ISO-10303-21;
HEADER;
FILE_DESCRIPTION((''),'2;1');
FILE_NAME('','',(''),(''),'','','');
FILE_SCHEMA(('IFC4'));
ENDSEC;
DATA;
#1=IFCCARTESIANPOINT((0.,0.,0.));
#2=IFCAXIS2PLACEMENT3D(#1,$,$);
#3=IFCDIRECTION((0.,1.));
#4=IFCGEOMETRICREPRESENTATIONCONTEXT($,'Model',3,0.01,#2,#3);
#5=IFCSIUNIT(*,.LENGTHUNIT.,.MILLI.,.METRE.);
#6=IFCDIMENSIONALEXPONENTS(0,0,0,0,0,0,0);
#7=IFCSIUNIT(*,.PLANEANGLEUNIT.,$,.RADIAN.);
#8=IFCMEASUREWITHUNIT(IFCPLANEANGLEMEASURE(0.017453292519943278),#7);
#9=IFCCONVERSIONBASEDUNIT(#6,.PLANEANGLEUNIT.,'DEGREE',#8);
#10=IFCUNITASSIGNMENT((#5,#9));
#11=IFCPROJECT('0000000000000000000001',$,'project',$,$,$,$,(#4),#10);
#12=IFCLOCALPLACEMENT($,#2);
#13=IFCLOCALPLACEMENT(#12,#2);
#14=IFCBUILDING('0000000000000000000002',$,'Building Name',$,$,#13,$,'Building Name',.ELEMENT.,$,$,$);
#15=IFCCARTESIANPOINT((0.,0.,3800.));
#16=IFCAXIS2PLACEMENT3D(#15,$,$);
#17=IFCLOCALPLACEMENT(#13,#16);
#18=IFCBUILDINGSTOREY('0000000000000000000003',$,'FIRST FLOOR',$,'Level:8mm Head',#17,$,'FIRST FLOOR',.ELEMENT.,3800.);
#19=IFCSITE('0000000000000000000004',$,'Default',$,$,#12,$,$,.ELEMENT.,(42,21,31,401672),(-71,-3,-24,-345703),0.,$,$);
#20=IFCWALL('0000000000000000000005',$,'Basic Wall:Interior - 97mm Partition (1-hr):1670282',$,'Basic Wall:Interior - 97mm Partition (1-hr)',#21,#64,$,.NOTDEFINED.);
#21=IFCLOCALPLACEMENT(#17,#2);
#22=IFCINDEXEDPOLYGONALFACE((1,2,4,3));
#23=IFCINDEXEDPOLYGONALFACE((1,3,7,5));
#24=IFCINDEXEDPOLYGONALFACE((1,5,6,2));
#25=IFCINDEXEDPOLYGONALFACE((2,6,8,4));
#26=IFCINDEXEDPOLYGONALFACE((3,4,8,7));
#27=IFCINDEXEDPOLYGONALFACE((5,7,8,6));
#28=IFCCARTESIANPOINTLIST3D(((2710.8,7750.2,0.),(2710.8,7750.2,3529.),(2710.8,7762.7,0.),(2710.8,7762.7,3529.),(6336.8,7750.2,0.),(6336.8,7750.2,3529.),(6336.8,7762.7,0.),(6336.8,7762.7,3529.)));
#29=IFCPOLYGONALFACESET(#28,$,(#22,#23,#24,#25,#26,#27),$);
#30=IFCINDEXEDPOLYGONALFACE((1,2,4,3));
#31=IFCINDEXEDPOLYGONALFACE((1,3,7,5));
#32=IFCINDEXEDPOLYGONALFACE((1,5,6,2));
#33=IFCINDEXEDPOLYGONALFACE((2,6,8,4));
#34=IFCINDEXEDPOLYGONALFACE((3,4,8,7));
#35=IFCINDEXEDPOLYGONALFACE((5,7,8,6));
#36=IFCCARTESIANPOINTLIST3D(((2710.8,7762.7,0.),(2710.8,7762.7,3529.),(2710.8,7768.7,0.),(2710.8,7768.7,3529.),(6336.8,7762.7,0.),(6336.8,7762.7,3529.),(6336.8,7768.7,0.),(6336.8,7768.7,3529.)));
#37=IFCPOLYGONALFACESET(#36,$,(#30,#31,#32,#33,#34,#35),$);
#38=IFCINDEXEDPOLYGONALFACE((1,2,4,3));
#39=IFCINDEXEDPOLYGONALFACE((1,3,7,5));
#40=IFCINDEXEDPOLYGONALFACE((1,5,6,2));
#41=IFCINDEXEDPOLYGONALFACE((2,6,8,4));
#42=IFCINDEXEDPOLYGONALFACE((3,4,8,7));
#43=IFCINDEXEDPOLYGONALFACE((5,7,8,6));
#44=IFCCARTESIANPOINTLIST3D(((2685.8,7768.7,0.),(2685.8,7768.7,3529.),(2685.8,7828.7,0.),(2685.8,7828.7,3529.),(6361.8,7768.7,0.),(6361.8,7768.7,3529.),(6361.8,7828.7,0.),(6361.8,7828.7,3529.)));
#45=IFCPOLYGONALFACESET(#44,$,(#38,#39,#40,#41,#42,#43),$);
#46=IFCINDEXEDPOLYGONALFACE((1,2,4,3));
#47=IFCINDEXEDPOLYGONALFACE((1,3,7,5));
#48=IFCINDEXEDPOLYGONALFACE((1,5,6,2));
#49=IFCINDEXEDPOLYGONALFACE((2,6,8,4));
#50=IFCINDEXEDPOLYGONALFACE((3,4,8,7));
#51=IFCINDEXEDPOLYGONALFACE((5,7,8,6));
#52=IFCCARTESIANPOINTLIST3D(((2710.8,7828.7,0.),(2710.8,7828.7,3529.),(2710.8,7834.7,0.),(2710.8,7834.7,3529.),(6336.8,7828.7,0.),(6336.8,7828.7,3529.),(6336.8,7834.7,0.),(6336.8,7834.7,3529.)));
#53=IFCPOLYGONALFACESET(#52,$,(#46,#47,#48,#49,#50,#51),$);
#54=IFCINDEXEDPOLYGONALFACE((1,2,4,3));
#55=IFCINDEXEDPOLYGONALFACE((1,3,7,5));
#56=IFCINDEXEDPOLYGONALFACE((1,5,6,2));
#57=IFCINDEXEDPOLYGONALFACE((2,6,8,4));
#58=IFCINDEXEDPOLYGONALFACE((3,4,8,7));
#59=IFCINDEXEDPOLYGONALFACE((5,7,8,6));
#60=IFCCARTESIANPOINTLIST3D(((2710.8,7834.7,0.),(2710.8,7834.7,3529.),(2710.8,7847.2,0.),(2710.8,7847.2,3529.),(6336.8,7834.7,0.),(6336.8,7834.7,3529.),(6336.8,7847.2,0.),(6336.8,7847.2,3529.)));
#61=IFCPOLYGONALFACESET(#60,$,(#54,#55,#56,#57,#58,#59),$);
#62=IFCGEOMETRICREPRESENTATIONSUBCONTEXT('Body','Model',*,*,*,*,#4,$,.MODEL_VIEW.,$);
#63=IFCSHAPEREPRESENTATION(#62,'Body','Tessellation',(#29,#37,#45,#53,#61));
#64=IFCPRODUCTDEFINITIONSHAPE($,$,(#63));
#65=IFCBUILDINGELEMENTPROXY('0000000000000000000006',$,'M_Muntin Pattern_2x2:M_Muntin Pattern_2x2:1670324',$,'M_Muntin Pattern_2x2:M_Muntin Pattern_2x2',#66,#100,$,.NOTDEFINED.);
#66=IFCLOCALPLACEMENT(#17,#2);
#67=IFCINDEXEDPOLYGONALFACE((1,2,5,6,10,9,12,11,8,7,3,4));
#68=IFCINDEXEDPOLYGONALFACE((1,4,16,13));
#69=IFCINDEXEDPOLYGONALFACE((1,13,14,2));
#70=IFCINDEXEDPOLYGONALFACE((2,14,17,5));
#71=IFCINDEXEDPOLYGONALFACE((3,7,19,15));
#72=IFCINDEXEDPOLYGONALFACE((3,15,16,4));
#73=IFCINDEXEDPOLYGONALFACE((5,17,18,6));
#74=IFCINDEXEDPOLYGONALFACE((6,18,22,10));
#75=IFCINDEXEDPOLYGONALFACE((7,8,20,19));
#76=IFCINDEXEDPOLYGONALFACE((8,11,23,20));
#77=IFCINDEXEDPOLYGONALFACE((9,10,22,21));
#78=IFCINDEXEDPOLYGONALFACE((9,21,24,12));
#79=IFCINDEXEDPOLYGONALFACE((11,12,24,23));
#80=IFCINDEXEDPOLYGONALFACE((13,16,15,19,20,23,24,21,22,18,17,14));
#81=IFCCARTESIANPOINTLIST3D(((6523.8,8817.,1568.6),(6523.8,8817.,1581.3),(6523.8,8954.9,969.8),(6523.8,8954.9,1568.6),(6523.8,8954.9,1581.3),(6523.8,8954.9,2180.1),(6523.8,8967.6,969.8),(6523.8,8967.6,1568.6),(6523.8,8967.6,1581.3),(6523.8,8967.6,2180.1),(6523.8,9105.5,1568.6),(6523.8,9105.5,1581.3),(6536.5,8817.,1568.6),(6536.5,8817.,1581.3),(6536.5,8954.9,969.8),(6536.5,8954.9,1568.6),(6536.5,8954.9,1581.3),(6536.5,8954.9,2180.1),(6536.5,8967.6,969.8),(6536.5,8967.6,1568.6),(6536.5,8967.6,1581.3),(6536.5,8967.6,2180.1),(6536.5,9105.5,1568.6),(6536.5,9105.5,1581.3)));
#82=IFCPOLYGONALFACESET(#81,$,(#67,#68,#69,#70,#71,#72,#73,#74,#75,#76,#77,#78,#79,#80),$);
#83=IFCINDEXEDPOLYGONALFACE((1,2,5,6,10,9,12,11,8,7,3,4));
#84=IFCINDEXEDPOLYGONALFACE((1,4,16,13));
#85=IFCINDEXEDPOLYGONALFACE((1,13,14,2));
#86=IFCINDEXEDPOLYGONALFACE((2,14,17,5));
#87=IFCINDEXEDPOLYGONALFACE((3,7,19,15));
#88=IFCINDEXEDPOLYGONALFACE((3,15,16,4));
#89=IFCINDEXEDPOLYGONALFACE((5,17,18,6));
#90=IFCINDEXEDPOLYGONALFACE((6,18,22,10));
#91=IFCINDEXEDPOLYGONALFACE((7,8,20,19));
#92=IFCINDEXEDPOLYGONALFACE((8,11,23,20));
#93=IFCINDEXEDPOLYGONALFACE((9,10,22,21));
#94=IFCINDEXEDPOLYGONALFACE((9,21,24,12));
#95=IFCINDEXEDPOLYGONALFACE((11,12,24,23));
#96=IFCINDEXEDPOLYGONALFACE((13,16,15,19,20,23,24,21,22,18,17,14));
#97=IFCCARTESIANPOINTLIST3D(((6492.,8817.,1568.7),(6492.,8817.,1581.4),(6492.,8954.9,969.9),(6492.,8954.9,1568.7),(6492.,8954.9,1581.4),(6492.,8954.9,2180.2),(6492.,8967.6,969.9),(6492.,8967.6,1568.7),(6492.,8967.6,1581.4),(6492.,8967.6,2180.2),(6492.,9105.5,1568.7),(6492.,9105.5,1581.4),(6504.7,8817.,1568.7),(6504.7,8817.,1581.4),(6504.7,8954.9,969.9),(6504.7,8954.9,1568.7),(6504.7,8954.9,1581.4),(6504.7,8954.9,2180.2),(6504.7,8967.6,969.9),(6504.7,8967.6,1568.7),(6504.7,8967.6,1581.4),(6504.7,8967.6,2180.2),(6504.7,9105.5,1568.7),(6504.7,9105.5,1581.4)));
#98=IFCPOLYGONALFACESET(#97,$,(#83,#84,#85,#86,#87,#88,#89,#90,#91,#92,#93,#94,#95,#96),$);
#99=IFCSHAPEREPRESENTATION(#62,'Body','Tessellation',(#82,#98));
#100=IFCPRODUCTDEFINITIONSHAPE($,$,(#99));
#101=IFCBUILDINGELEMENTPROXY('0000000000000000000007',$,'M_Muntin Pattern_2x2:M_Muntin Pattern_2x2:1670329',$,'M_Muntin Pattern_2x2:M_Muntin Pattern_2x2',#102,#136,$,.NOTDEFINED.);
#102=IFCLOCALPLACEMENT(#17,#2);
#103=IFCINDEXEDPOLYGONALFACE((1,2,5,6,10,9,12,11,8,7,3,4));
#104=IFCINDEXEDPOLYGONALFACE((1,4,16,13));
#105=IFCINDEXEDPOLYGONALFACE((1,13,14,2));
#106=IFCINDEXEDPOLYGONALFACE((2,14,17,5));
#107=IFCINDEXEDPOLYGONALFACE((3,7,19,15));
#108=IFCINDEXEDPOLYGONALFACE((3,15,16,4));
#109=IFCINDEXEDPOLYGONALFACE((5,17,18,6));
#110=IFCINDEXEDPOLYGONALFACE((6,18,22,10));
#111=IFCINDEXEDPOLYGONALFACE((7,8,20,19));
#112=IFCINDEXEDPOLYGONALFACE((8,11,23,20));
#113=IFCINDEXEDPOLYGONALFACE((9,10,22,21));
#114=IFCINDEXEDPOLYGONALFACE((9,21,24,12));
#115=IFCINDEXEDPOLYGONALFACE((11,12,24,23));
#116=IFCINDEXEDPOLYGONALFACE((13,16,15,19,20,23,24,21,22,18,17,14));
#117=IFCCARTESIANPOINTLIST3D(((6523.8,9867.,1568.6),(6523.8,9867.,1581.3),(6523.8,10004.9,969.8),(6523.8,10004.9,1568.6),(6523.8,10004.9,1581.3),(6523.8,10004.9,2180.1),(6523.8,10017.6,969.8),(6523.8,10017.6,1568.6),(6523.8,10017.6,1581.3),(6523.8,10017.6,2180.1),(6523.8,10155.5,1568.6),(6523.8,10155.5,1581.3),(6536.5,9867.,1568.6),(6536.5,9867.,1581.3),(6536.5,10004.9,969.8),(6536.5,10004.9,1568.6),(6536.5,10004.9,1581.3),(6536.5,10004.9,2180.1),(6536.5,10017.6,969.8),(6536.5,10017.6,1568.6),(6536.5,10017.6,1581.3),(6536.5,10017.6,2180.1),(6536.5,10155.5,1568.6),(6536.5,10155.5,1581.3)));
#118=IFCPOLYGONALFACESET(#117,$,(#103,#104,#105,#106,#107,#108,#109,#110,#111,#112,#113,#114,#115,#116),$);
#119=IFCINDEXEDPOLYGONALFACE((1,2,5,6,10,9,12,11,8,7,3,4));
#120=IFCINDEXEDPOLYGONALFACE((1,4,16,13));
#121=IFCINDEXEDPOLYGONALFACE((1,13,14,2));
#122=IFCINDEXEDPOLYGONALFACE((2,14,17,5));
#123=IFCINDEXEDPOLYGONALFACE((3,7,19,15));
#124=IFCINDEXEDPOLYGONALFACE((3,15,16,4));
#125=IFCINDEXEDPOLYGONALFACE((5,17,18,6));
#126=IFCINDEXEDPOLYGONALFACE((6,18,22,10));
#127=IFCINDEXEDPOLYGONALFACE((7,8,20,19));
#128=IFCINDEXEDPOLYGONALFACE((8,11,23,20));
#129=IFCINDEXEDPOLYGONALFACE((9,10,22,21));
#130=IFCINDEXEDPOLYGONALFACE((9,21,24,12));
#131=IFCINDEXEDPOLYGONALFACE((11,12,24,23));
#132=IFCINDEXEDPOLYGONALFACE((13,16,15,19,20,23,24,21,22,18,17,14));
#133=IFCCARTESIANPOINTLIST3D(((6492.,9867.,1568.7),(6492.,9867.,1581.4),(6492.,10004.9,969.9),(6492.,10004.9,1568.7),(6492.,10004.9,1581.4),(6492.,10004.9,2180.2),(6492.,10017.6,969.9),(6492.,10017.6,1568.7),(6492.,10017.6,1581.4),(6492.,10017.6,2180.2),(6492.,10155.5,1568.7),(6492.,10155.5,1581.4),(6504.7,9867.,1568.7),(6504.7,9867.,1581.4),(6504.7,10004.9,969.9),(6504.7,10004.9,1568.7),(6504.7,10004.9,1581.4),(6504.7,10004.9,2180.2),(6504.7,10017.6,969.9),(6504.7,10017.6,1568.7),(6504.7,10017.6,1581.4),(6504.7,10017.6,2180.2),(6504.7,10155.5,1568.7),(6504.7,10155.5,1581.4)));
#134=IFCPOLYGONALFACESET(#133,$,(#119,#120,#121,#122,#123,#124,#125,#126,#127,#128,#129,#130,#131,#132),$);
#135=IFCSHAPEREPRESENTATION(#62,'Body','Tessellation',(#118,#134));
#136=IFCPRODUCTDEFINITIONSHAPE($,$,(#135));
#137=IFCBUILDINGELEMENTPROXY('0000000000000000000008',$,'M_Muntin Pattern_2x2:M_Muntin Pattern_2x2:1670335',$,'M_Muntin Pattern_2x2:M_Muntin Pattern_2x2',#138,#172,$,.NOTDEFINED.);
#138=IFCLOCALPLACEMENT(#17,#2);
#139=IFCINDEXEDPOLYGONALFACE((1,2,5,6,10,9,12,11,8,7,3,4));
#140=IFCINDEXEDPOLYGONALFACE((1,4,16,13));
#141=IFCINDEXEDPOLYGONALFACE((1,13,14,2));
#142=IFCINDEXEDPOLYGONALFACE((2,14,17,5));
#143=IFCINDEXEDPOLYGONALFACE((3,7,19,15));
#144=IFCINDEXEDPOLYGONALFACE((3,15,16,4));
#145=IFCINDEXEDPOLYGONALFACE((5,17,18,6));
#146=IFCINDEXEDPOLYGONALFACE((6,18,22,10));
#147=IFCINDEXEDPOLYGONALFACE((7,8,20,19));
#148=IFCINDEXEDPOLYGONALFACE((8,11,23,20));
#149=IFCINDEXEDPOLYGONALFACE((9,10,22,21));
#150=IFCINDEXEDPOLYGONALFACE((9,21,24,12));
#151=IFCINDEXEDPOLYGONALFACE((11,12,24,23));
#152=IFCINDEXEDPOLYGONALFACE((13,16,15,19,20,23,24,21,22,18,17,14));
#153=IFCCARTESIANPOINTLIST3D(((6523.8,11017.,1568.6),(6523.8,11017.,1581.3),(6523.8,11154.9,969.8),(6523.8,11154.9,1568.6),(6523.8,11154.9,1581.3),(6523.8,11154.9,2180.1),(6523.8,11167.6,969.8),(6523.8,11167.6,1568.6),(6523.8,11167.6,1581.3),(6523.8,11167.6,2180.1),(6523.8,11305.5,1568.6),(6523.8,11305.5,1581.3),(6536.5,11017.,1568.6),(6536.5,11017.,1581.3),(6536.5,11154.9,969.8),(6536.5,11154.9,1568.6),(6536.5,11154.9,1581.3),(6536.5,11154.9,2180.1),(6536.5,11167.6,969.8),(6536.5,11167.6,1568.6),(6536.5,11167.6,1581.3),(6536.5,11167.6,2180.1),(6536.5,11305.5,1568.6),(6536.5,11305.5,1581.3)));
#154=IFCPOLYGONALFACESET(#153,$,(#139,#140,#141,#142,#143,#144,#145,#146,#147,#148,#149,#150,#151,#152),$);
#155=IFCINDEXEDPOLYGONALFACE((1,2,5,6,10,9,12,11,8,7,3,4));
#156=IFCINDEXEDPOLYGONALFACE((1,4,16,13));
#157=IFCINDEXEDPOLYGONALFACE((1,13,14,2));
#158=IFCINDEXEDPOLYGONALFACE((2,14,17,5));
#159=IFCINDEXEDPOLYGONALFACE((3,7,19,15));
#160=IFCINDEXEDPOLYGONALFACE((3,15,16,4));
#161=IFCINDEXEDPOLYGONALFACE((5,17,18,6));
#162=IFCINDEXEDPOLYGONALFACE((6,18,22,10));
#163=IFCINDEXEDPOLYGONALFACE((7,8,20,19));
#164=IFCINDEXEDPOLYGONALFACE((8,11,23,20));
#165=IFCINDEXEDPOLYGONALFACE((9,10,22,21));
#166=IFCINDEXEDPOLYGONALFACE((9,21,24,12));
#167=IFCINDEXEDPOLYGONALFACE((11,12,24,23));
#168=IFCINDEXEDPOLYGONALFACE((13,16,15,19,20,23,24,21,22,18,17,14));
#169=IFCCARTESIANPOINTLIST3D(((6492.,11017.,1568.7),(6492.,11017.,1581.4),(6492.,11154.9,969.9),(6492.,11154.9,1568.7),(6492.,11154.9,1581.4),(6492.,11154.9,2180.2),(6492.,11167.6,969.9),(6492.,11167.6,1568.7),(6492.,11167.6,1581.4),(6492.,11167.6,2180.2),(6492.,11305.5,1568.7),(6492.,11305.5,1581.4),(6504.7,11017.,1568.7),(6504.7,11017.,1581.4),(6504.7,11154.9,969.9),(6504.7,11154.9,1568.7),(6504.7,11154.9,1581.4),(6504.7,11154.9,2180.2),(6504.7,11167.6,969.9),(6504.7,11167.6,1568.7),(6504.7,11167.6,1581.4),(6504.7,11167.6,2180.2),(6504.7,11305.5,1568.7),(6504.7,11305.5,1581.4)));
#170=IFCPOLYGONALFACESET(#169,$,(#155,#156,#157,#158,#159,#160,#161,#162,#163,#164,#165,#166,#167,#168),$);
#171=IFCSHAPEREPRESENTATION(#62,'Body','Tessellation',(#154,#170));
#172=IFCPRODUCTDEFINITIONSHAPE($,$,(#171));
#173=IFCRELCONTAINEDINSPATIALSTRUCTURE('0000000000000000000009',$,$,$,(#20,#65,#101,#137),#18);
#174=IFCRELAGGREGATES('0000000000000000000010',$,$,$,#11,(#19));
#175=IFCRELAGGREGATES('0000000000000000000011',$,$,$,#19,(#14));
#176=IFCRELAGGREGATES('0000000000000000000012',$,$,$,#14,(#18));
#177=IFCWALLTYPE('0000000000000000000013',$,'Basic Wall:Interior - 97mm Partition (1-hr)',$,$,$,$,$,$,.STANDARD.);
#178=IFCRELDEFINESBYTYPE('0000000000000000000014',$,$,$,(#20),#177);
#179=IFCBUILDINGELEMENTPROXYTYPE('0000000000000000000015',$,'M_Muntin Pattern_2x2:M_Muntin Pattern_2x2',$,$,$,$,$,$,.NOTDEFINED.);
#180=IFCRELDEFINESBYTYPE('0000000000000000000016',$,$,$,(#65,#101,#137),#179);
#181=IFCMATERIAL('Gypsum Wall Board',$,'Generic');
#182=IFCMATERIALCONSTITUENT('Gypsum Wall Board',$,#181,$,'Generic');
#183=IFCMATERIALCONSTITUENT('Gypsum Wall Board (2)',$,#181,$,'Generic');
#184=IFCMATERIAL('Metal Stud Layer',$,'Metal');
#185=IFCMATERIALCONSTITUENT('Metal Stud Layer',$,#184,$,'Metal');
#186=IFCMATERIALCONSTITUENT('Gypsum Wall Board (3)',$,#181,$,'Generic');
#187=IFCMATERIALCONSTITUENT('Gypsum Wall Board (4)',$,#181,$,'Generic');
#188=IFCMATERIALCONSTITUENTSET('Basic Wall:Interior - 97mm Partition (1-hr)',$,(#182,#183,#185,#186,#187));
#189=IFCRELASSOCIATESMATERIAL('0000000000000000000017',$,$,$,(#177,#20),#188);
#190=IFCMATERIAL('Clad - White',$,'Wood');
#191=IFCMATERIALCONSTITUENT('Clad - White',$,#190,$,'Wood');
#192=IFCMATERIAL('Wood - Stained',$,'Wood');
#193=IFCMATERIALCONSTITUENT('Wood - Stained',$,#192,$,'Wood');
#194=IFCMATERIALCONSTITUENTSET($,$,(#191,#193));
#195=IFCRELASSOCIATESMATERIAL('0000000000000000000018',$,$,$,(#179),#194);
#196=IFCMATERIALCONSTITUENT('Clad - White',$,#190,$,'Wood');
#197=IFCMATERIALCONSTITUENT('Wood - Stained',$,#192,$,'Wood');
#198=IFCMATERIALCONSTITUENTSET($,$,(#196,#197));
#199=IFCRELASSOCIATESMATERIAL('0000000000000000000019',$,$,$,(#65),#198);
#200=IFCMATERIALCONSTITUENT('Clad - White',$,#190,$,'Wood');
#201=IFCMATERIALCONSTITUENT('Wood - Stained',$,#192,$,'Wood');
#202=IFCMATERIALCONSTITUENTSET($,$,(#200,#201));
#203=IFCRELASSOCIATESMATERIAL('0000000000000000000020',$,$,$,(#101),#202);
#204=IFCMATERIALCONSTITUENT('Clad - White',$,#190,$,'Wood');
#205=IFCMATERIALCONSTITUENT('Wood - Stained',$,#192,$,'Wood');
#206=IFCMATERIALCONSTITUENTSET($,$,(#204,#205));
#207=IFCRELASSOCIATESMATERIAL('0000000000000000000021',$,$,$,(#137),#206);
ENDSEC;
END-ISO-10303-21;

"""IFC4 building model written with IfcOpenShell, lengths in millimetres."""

from ifc_helpers import new_model, entity, si_unit, converted_unit, direction, frame, origin, place, context, subcontext, project, spatial, indexed_curve, outline, extrude, source, transform, mapped, material, constituent, constituent_set, type_object, type_shapes, element, save


model = new_model("IFC4")

# Units and contexts
model_context = context("Model", 3, precision=0.01, world=origin(), true_north=direction((0.0, 1.0)))
body_context = subcontext(model_context, "Body", "Model", "MODEL_VIEW")
ifc_project = project(units=[si_unit("LENGTHUNIT", "METRE", prefix="MILLI"), converted_unit("PLANEANGLEUNIT", "DEGREE", entity("IfcPlaneAngleMeasure", 0.017453292519943278), si_unit("PLANEANGLEUNIT", "RADIAN"), dimensions=[0, 0, 0, 0, 0, 0, 0])], contexts=[model_context])

# Site, building, storey
site_placement = place(None, origin())
site = spatial("IfcSite", under=ifc_project, at=site_placement, Name="Default", CompositionType="ELEMENT", RefLatitude=(42, 21, 31, 401672), RefLongitude=(-71, -3, -24, -345703), RefElevation=0.0)
building_placement = place(site_placement, origin())
building = spatial("IfcBuilding", under=site, at=building_placement, Name="Building Name", LongName="Building Name", CompositionType="ELEMENT")
storey_placement = place(building_placement, frame((0.0, 0.0, 3800.0)))
storey = spatial("IfcBuildingStorey", under=building, at=storey_placement, Name="FIRST FLOOR", ObjectType="Level:8mm Head", LongName="FIRST FLOOR", CompositionType="ELEMENT", Elevation=3800.0)

# Wall
ifc_material_1 = material(Name="Gypsum Wall Board", Category="Generic")
ifc_constituent_1 = constituent(ifc_material_1, Name="Gypsum Wall Board", Category="Generic")
ifc_constituent_2 = constituent(ifc_material_1, Name="Gypsum Wall Board (2)", Category="Generic")
ifc_material_2 = material(Name="Metal Stud Layer", Category="Metal")
ifc_constituent_3 = constituent(ifc_material_2, Name="Metal Stud Layer", Category="Metal")
ifc_constituent_4 = constituent(ifc_material_1, Name="Gypsum Wall Board (3)", Category="Generic")
ifc_constituent_5 = constituent(ifc_material_1, Name="Gypsum Wall Board (4)", Category="Generic")
ifc_constituent_set_1 = constituent_set(constituents=[ifc_constituent_1, ifc_constituent_2, ifc_constituent_3, ifc_constituent_4, ifc_constituent_5], Name="Basic Wall:Interior - 97mm Partition (1-hr)")
wall_type = type_object("IfcWallType", Name="Basic Wall:Interior - 97mm Partition (1-hr)", PredefinedType="STANDARD", material=ifc_constituent_set_1)
wall_placement = place(storey_placement, frame((6336.8, 7798.7, 0.0), z_axis=(0.0, 0.0, 1.0), x_axis=(-1.0, 0.0, 0.0)))
element("IfcWall", 1, at=wall_placement, inside=storey, type_object=wall_type, material=ifc_constituent_set_1, Name="Basic Wall:Interior - 97mm Partition (1-hr):1670282", ObjectType="Basic Wall:Interior - 97mm Partition (1-hr)", PredefinedType="NOTDEFINED", context=body_context, shape_type="SweptSolid", body=[
    extrude(outline(indexed_curve([(-6.2, -1764.5), (6.2, -1764.5), (6.2, 1764.5), (-6.2, 1764.5), (-6.2, -1764.5)], self_intersect=False)), frame((3626.0, 42.3, 1764.5), z_axis=(-1.0, 0.0, 0.0), x_axis=(0.0, -1.0, 0.0)), (0.0, 0.0, 1.0), 3626.0),
    extrude(outline(indexed_curve([(-1764.5, -3.0), (1764.5, -3.0), (1764.5, 3.0), (-1764.5, 3.0), (-1764.5, -3.0)], self_intersect=False)), frame((3626.0, 33.0, 1764.5), z_axis=(-1.0, 0.0, 0.0), x_axis=(0.0, 0.0, 1.0)), (0.0, 0.0, 1.0), 3626.0),
    extrude(outline(indexed_curve([(-1764.5, -30.0), (1764.5, -30.0), (1764.5, 30.0), (-1764.5, 30.0), (-1764.5, -30.0)], self_intersect=False)), frame((3651.0, 0.0, 1764.5), z_axis=(-1.0, 0.0, 0.0), x_axis=(0.0, 0.0, 1.0)), (0.0, 0.0, 1.0), 3676.0),
    extrude(outline(indexed_curve([(-1764.5, -3.0), (1764.5, -3.0), (1764.5, 3.0), (-1764.5, 3.0), (-1764.5, -3.0)], self_intersect=False)), frame((3626.0, -33.0, 1764.5), z_axis=(-1.0, 0.0, 0.0), x_axis=(0.0, 0.0, 1.0)), (0.0, 0.0, 1.0), 3626.0),
    extrude(outline(indexed_curve([(-6.2, -1764.5), (6.2, -1764.5), (6.2, 1764.5), (-6.2, 1764.5), (-6.2, -1764.5)], self_intersect=False)), frame((3626.0, -42.2, 1764.5), z_axis=(-1.0, 0.0, 0.0), x_axis=(0.0, 1.0, 0.0)), (0.0, 0.0, 1.0), 3626.0),
])

# Building element proxies
ifc_material_3 = material(Name="Clad - White", Category="Wood")
ifc_constituent_6 = constituent(ifc_material_3, Name="Clad - White", Category="Wood")
ifc_material_4 = material(Name="Wood - Stained", Category="Wood")
ifc_constituent_7 = constituent(ifc_material_4, Name="Wood - Stained", Category="Wood")
ifc_constituent_set_2 = constituent_set(constituents=[ifc_constituent_6, ifc_constituent_7])
ifc_constituent_8 = constituent(ifc_material_3, Name="Clad - White", Category="Wood")
ifc_constituent_9 = constituent(ifc_material_4, Name="Wood - Stained", Category="Wood")
ifc_constituent_set_3 = constituent_set(constituents=[ifc_constituent_8, ifc_constituent_9])
building_element_proxy_type_1 = type_object("IfcBuildingElementProxyType", Name="M_Muntin Pattern_2x2:M_Muntin Pattern_2x2", PredefinedType="NOTDEFINED", material=ifc_constituent_set_3)
shared_shape_1 = source(origin(), body_context, "Body", "SweptSolid", [
    extrude(outline(indexed_curve([(6.4, -6.4), (605.1, -6.4), (605.1, 6.3), (6.4, 6.3), (6.4, 144.2), (-6.3, 144.2), (-6.3, 6.3), (-605.2, 6.3), (-605.2, -6.4), (-6.3, -6.4), (-6.3, -144.2), (6.4, -144.2), (6.4, -6.4)], self_intersect=False)), frame((0.0, -22.2, 605.1), z_axis=(0.0, 1.0, 0.0), x_axis=(0.0, 0.0, 1.0)), (0.0, 0.0, 1.0), 12.7),
    extrude(outline(indexed_curve([(6.4, -6.4), (605.2, -6.4), (605.2, 6.3), (6.4, 6.3), (6.4, 144.2), (-6.3, 144.2), (-6.3, 6.3), (-605.2, 6.3), (-605.2, -6.4), (-6.3, -6.4), (-6.3, -144.2), (6.4, -144.2), (6.4, -6.4)], self_intersect=False)), frame((0.0, 9.5, 605.2), z_axis=(0.0, 1.0, 0.0), x_axis=(0.0, 0.0, 1.0)), (0.0, 0.0, 1.0), 12.7),
])
type_shapes(building_element_proxy_type_1, [shared_shape_1])
proxy_1_placement = place(storey_placement, frame((6514.3, 8961.3, 969.9), z_axis=(0.0, 0.0, 1.0), x_axis=(0.0, 1.0, 0.0)))
element("IfcBuildingElementProxy", 2, at=proxy_1_placement, inside=storey, type_object=building_element_proxy_type_1, material=ifc_constituent_set_2, Name="M_Muntin Pattern_2x2:M_Muntin Pattern_2x2:1670324", ObjectType="M_Muntin Pattern_2x2:M_Muntin Pattern_2x2", PredefinedType="NOTDEFINED", context=body_context, shape_type="MappedRepresentation", body=[
    mapped(shared_shape_1, transform((0.0, 0.0, 0.0), scale=1.0)),
])
ifc_constituent_10 = constituent(ifc_material_3, Name="Clad - White", Category="Wood")
ifc_constituent_11 = constituent(ifc_material_4, Name="Wood - Stained", Category="Wood")
ifc_constituent_set_4 = constituent_set(constituents=[ifc_constituent_10, ifc_constituent_11])
proxy_2_placement = place(storey_placement, frame((6514.3, 10011.3, 969.9), z_axis=(0.0, 0.0, 1.0), x_axis=(0.0, 1.0, 0.0)))
element("IfcBuildingElementProxy", 3, at=proxy_2_placement, inside=storey, type_object=building_element_proxy_type_1, material=ifc_constituent_set_4, Name="M_Muntin Pattern_2x2:M_Muntin Pattern_2x2:1670329", ObjectType="M_Muntin Pattern_2x2:M_Muntin Pattern_2x2", PredefinedType="NOTDEFINED", context=body_context, shape_type="MappedRepresentation", body=[
    mapped(shared_shape_1, transform((0.0, 0.0, 0.0), scale=1.0)),
])
ifc_constituent_12 = constituent(ifc_material_3, Name="Clad - White", Category="Wood")
ifc_constituent_13 = constituent(ifc_material_4, Name="Wood - Stained", Category="Wood")
ifc_constituent_set_5 = constituent_set(constituents=[ifc_constituent_12, ifc_constituent_13])
proxy_3_placement = place(storey_placement, frame((6514.3, 11161.3, 969.9), z_axis=(0.0, 0.0, 1.0), x_axis=(0.0, 1.0, 0.0)))
element("IfcBuildingElementProxy", 4, at=proxy_3_placement, inside=storey, type_object=building_element_proxy_type_1, material=ifc_constituent_set_5, Name="M_Muntin Pattern_2x2:M_Muntin Pattern_2x2:1670335", ObjectType="M_Muntin Pattern_2x2:M_Muntin Pattern_2x2", PredefinedType="NOTDEFINED", context=body_context, shape_type="MappedRepresentation", body=[
    mapped(shared_shape_1, transform((0.0, 0.0, 0.0), scale=1.0)),
])

save(model, "model.ifc")
